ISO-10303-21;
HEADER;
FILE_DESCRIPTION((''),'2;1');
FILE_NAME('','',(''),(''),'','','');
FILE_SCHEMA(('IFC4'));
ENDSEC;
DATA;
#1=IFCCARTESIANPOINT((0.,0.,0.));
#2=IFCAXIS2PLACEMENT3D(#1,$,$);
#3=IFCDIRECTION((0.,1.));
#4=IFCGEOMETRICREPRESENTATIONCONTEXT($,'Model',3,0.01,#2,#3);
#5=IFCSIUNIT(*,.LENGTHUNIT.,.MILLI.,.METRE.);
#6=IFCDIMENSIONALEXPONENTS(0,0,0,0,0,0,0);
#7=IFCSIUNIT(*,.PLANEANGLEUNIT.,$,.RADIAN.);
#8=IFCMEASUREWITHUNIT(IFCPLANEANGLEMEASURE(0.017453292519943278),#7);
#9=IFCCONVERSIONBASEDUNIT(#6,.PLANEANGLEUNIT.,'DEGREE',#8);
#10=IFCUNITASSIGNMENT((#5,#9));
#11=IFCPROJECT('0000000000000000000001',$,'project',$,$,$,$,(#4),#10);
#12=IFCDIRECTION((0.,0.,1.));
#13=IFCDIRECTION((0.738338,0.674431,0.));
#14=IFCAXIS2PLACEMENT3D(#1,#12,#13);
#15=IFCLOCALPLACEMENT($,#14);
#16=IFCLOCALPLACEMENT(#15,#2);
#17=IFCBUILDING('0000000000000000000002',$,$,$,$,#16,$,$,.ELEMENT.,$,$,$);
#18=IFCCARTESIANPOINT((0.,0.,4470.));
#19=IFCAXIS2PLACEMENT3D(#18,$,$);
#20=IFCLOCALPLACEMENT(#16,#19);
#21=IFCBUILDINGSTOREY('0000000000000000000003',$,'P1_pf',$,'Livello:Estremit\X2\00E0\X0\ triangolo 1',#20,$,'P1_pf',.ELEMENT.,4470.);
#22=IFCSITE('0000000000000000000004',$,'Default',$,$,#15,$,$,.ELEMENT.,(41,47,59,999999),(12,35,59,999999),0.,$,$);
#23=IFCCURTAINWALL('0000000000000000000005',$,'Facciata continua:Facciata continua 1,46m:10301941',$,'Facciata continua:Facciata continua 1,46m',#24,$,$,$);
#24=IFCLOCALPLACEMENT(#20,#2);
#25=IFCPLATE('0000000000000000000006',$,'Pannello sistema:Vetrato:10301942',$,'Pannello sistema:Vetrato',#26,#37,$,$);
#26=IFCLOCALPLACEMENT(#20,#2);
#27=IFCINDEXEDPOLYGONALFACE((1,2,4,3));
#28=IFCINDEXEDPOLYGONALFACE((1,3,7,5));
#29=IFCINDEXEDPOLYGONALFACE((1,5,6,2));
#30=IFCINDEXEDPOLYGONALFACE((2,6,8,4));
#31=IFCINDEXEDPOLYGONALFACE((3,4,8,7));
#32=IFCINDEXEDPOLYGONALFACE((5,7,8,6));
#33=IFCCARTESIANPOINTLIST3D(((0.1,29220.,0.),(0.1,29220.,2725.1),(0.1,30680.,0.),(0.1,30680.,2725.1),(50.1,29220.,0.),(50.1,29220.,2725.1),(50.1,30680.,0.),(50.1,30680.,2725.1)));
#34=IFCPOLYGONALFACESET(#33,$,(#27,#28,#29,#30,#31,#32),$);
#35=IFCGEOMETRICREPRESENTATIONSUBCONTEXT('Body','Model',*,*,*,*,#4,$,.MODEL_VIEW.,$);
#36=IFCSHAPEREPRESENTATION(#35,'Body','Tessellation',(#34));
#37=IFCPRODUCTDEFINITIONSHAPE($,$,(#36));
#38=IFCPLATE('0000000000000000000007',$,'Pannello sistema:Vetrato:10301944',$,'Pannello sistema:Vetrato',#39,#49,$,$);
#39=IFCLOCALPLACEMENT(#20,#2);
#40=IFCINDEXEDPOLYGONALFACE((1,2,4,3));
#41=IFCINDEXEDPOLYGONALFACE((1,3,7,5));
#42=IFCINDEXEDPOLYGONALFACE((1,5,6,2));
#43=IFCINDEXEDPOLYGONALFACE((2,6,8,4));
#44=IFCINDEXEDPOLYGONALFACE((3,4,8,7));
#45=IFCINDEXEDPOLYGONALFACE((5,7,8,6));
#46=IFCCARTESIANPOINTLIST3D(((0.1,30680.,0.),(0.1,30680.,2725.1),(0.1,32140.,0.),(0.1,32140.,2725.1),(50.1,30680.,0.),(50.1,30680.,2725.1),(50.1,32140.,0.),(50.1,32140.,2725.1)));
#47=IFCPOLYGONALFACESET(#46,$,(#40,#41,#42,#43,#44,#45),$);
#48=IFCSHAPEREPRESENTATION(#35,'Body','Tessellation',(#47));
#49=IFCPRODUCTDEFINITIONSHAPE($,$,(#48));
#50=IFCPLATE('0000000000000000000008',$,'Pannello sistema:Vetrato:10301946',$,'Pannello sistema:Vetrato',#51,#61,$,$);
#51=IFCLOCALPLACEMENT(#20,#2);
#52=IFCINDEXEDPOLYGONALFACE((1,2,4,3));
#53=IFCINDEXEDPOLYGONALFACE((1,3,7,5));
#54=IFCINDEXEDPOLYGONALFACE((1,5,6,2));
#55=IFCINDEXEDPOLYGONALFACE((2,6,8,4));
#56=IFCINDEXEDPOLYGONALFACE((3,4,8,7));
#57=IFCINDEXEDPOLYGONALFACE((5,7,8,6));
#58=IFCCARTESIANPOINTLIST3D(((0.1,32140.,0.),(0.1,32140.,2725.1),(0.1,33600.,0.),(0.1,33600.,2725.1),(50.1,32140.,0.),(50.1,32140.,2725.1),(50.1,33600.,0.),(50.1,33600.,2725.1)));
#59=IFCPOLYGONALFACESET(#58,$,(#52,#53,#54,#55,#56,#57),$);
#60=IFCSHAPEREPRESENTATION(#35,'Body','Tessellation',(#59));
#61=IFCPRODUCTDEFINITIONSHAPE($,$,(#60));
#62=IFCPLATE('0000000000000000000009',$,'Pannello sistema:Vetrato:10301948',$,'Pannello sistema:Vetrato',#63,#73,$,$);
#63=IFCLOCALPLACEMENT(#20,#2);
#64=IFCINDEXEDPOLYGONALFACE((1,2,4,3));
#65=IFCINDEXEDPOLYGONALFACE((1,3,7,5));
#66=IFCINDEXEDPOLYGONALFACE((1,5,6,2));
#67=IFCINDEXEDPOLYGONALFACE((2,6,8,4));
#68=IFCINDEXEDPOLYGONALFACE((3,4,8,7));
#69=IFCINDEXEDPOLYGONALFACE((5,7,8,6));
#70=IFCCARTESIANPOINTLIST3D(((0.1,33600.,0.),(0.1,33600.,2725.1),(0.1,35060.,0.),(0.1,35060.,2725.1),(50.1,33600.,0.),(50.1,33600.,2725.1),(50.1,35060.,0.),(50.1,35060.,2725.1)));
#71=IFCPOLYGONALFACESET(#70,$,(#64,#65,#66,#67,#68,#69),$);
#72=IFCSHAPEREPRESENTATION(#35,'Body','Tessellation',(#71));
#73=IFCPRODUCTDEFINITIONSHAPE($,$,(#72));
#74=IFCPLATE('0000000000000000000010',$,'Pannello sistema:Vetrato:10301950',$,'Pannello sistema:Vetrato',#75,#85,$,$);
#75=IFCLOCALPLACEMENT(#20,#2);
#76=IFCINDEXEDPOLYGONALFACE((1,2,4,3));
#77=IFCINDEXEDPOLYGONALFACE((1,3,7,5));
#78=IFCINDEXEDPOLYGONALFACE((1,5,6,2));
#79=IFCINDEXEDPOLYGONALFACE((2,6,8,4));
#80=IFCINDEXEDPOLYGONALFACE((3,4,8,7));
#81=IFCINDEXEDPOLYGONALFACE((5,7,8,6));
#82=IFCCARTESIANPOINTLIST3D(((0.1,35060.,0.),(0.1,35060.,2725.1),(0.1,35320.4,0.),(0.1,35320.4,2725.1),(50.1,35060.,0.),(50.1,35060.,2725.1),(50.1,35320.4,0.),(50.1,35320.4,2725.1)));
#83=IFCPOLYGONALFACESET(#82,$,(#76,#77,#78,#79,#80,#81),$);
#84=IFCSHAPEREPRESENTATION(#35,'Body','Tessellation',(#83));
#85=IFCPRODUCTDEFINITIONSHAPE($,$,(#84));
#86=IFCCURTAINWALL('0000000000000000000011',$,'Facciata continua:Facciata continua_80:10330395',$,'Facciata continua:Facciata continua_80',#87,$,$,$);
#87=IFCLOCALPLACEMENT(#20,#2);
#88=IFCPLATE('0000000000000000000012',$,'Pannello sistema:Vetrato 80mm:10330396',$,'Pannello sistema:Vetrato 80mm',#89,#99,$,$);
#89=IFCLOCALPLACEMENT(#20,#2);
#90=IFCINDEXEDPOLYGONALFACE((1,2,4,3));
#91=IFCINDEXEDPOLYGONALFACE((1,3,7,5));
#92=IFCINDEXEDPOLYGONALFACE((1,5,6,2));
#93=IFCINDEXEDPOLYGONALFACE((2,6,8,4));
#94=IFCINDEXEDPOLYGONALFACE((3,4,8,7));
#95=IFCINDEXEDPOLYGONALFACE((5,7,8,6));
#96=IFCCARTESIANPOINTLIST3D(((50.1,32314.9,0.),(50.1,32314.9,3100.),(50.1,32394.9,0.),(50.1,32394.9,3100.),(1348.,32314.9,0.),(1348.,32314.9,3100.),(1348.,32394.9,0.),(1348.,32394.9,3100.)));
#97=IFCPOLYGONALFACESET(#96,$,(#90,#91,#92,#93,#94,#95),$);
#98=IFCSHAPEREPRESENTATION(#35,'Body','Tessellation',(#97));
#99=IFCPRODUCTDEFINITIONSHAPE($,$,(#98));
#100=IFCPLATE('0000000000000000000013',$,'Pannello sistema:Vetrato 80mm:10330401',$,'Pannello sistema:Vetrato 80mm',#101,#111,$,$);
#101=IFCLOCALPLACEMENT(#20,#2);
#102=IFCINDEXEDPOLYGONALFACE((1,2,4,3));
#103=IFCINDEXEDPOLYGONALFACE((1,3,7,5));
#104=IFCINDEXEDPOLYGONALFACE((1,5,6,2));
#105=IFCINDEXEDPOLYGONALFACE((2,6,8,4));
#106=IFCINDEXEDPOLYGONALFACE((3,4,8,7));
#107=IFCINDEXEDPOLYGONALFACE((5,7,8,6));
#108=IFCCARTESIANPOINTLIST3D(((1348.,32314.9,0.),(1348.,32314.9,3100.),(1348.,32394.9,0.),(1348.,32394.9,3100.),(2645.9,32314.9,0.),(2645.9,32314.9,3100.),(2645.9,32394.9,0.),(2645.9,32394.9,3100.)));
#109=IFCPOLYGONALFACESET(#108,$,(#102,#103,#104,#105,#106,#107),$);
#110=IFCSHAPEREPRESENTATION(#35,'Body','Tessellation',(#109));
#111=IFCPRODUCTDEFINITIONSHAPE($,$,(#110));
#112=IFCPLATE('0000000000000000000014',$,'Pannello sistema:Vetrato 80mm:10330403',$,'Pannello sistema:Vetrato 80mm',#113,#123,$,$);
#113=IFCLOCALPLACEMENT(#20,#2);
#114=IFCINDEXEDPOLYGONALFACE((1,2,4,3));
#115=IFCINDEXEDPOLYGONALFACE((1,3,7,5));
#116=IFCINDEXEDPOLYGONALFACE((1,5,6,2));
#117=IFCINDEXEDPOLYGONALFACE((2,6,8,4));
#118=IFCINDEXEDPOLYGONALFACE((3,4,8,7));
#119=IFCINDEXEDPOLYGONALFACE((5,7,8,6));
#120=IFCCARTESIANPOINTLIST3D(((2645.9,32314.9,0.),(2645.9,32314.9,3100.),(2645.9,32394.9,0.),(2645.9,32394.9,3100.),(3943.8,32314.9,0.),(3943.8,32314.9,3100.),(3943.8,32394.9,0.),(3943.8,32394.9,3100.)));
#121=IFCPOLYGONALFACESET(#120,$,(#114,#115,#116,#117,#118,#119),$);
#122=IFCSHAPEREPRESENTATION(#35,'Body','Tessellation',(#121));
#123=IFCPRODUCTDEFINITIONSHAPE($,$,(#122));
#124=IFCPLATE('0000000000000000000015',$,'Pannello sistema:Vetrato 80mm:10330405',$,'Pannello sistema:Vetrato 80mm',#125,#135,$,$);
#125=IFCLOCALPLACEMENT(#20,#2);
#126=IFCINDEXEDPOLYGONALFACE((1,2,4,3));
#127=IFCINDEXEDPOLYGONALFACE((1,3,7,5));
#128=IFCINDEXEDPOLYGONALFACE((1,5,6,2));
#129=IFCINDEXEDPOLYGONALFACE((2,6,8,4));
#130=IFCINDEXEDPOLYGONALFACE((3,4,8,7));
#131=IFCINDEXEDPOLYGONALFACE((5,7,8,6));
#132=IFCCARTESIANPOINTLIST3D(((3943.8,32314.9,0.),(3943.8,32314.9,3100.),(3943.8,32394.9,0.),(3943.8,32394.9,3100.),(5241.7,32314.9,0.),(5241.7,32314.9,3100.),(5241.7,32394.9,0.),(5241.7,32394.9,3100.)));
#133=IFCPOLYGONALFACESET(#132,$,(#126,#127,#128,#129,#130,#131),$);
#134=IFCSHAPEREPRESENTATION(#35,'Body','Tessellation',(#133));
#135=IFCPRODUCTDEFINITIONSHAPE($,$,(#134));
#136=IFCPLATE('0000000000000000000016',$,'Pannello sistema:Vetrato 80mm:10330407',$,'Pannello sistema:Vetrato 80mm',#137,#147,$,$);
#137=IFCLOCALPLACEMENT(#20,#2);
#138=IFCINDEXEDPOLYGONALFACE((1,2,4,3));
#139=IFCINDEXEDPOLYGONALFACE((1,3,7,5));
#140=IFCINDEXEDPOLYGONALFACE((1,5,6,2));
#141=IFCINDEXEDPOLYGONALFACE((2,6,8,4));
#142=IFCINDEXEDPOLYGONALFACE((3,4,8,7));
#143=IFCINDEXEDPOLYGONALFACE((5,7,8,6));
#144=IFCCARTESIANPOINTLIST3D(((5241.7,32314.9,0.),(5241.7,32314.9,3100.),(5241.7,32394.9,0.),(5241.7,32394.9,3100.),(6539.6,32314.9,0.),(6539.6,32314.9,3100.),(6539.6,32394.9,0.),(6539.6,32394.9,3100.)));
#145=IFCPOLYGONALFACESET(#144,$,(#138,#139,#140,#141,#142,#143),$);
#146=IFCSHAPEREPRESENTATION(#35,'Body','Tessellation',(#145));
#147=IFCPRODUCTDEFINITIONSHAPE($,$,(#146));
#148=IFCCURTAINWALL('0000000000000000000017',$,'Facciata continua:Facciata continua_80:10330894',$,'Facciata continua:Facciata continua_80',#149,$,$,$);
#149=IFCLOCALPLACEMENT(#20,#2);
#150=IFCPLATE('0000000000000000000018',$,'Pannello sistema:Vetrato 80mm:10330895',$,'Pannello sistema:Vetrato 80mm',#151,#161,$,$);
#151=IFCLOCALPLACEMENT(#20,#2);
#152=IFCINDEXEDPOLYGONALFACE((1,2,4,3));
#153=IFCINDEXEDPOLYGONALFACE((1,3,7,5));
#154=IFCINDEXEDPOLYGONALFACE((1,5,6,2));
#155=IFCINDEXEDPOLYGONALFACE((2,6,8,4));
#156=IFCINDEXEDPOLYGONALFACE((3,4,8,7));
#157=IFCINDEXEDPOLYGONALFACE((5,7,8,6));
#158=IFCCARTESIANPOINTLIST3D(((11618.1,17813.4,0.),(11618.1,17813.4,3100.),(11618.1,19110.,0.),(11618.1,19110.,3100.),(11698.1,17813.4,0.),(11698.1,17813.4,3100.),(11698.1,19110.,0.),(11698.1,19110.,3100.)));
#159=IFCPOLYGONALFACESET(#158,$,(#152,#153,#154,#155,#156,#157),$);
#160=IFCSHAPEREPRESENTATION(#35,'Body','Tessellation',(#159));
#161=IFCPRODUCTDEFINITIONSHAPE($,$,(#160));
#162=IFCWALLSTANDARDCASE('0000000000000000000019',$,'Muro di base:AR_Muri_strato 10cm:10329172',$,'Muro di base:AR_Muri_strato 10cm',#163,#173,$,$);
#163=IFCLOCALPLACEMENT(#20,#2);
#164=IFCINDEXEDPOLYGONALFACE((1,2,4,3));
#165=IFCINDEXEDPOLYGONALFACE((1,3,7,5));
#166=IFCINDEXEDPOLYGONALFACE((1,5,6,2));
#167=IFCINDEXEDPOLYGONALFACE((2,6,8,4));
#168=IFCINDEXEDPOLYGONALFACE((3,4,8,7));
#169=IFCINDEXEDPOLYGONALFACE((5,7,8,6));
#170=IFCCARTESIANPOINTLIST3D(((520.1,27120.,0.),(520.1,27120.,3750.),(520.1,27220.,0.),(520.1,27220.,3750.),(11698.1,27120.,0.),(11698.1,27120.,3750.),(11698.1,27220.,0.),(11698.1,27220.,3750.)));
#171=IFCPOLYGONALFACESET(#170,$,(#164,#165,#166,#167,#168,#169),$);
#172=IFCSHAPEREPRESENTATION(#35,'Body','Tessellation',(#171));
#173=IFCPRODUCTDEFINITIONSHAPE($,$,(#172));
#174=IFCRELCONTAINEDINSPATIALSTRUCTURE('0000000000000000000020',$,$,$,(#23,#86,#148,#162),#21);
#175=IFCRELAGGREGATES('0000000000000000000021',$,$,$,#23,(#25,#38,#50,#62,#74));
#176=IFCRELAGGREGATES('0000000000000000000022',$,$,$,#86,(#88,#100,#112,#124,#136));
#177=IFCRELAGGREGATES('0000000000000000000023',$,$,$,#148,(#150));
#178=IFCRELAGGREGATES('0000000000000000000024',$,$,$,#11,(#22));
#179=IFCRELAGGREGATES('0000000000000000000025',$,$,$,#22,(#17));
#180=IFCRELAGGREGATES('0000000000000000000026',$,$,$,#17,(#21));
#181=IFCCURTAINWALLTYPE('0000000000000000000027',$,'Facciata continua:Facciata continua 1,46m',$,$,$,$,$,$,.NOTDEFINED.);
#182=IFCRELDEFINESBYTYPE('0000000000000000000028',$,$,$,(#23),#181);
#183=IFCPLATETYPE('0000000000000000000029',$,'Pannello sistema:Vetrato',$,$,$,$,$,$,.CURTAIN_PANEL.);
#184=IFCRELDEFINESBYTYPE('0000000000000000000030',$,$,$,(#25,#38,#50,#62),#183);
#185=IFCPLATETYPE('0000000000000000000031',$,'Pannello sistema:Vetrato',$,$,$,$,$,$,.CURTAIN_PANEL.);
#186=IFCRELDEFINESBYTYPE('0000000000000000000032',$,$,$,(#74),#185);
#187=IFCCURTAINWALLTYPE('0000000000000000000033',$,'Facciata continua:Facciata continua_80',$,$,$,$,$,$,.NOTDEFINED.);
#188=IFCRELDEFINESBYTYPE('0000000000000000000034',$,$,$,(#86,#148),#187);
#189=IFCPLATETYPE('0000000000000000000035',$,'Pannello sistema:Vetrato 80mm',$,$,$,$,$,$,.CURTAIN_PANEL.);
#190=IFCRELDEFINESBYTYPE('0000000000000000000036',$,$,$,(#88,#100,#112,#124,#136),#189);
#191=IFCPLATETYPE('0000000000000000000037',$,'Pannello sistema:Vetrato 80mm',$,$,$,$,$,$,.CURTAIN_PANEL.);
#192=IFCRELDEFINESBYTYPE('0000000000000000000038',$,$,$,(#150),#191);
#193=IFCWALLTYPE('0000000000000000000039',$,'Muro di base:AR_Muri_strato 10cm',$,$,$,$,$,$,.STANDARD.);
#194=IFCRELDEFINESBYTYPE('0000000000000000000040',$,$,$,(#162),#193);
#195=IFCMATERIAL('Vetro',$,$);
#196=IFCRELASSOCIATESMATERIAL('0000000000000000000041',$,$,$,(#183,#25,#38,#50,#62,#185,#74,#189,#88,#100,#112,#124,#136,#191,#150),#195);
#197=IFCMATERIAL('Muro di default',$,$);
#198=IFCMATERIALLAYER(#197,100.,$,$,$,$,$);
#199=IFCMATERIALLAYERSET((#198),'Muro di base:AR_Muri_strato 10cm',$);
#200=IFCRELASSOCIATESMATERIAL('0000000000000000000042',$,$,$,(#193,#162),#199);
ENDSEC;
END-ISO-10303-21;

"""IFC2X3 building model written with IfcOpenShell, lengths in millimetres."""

from ifc_helpers import new_model, entity, si_unit, converted_unit, direction, frame, frame_2d, origin, origin_2d_with_axis, place, context, subcontext, project, spatial, rectangle, extrude, source, transform, mapped, material, layer, layer_set, layer_usage, type_object, type_shapes, element, aggregate, save


model = new_model("IFC2X3")

# Units and contexts
model_context = context("Model", 3, precision=0.01, world=origin(), true_north=direction((0.0, 1.0)))
body_context = subcontext(model_context, "Body", "Model", "MODEL_VIEW")
ifc_project = project(units=[si_unit("LENGTHUNIT", "METRE", prefix="MILLI"), converted_unit("PLANEANGLEUNIT", "DEGREE", entity("IfcPlaneAngleMeasure", 0.017453292519943278), si_unit("PLANEANGLEUNIT", "RADIAN"), dimensions=[0, 0, 0, 0, 0, 0, 0])], contexts=[model_context])

# Site, building, storey
site_placement = place(None, frame((0.0, 0.0, 0.0), z_axis=(0.0, 0.0, 1.0), x_axis=(0.738338, 0.674431, 0.0)))
site = spatial("IfcSite", under=ifc_project, at=site_placement, Name="Default", CompositionType="ELEMENT", RefLatitude=(41, 47, 59, 999999), RefLongitude=(12, 35, 59, 999999), RefElevation=0.0)
building_placement = place(site_placement, origin())
building = spatial("IfcBuilding", under=site, at=building_placement, CompositionType="ELEMENT")
storey_placement = place(building_placement, frame((0.0, 0.0, 4470.0)))
storey = spatial("IfcBuildingStorey", under=building, at=storey_placement, Name="P1_pf", ObjectType="Livello:Estremità triangolo 1", LongName="P1_pf", CompositionType="ELEMENT", Elevation=4470.0)

# Curtain walls, plates
curtain_wall_type_1 = type_object("IfcCurtainWallType", Name="Facciata continua:Facciata continua 1,46m", PredefinedType="NOTDEFINED")
curtain_wall_1_placement = place(storey_placement, frame((0.0, 0.0, -4470.0)))
curtain_wall_1 = element("IfcCurtainWall", 1, at=curtain_wall_1_placement, inside=storey, type_object=curtain_wall_type_1, Name="Facciata continua:Facciata continua 1,46m:10301941", ObjectType="Facciata continua:Facciata continua 1,46m")
ifc_material_1 = material(Name="Vetro")
plate_type_1 = type_object("IfcPlateType", Name="Pannello sistema:Vetrato", PredefinedType="CURTAIN_PANEL", material=ifc_material_1)
shared_shape_1 = source(origin(), body_context, "Body", "SweptSolid", [
    extrude(rectangle(XDim=50.0, YDim=1460.0, at=origin_2d_with_axis()), frame((0.0, -25.0, 0.0), z_axis=(0.0, 0.0, 1.0), x_axis=(0.0, 1.0, 0.0)), (0.0, 0.0, 1.0), 2725.1),
])
type_shapes(plate_type_1, [shared_shape_1])
plate_1_placement = place(curtain_wall_1_placement, frame((0.1, 29950.0, 4470.0), z_axis=(0.0, 0.0, 1.0), x_axis=(0.0, 1.0, 0.0)))
plate_1 = element("IfcPlate", 2, at=plate_1_placement, type_object=plate_type_1, material=ifc_material_1, Name="Pannello sistema:Vetrato:10301942", ObjectType="Pannello sistema:Vetrato", context=body_context, shape_type="MappedRepresentation", body=[
    mapped(shared_shape_1, transform((0.0, 0.0, 0.0), scale=1.0)),
])
plate_2_placement = place(curtain_wall_1_placement, frame((0.1, 31410.0, 4470.0), z_axis=(0.0, 0.0, 1.0), x_axis=(0.0, 1.0, 0.0)))
plate_2 = element("IfcPlate", 3, at=plate_2_placement, type_object=plate_type_1, material=ifc_material_1, Name="Pannello sistema:Vetrato:10301944", ObjectType="Pannello sistema:Vetrato", context=body_context, shape_type="MappedRepresentation", body=[
    mapped(shared_shape_1, transform((0.0, 0.0, 0.0), scale=1.0)),
])
plate_3_placement = place(curtain_wall_1_placement, frame((0.1, 32870.0, 4470.0), z_axis=(0.0, 0.0, 1.0), x_axis=(0.0, 1.0, 0.0)))
plate_3 = element("IfcPlate", 4, at=plate_3_placement, type_object=plate_type_1, material=ifc_material_1, Name="Pannello sistema:Vetrato:10301946", ObjectType="Pannello sistema:Vetrato", context=body_context, shape_type="MappedRepresentation", body=[
    mapped(shared_shape_1, transform((0.0, 0.0, 0.0), scale=1.0)),
])
plate_4_placement = place(curtain_wall_1_placement, frame((0.1, 34330.0, 4470.0), z_axis=(0.0, 0.0, 1.0), x_axis=(0.0, 1.0, 0.0)))
plate_4 = element("IfcPlate", 5, at=plate_4_placement, type_object=plate_type_1, material=ifc_material_1, Name="Pannello sistema:Vetrato:10301948", ObjectType="Pannello sistema:Vetrato", context=body_context, shape_type="MappedRepresentation", body=[
    mapped(shared_shape_1, transform((0.0, 0.0, 0.0), scale=1.0)),
])
plate_type_2 = type_object("IfcPlateType", Name="Pannello sistema:Vetrato", PredefinedType="CURTAIN_PANEL", material=ifc_material_1)
shared_shape_2 = source(origin(), body_context, "Body", "SweptSolid", [
    extrude(rectangle(XDim=50.0, YDim=260.4, at=origin_2d_with_axis()), frame((0.0, -25.0, 0.0), z_axis=(0.0, 0.0, 1.0), x_axis=(0.0, 1.0, 0.0)), (0.0, 0.0, 1.0), 2725.1),
])
type_shapes(plate_type_2, [shared_shape_2])
plate_5_placement = place(curtain_wall_1_placement, frame((0.1, 35190.2, 4470.0), z_axis=(0.0, 0.0, 1.0), x_axis=(0.0, 1.0, 0.0)))
plate_5 = element("IfcPlate", 6, at=plate_5_placement, type_object=plate_type_2, material=ifc_material_1, Name="Pannello sistema:Vetrato:10301950", ObjectType="Pannello sistema:Vetrato", context=body_context, shape_type="MappedRepresentation", body=[
    mapped(shared_shape_2, transform((0.0, 0.0, 0.0), scale=1.0)),
])
aggregate(curtain_wall_1, [plate_1, plate_2, plate_3, plate_4, plate_5])
curtain_wall_type_2 = type_object("IfcCurtainWallType", Name="Facciata continua:Facciata continua_80", PredefinedType="NOTDEFINED")
curtain_wall_2_placement = place(storey_placement, frame((0.0, 0.0, -4470.0)))
curtain_wall_2 = element("IfcCurtainWall", 7, at=curtain_wall_2_placement, inside=storey, type_object=curtain_wall_type_2, Name="Facciata continua:Facciata continua_80:10330395", ObjectType="Facciata continua:Facciata continua_80")
plate_type_3 = type_object("IfcPlateType", Name="Pannello sistema:Vetrato 80mm", PredefinedType="CURTAIN_PANEL", material=ifc_material_1)
shared_shape_3 = source(origin(), body_context, "Body", "SweptSolid", [
    extrude(rectangle(XDim=80.0, YDim=1297.9, at=origin_2d_with_axis()), frame((0.0, -40.0, 0.0), z_axis=(0.0, 0.0, 1.0), x_axis=(0.0, 1.0, 0.0)), (0.0, 0.0, 1.0), 3100.0),
])
type_shapes(plate_type_3, [shared_shape_3])
plate_6_placement = place(curtain_wall_2_placement, frame((699.0, 32394.9, 4470.0)))
plate_6 = element("IfcPlate", 8, at=plate_6_placement, type_object=plate_type_3, material=ifc_material_1, Name="Pannello sistema:Vetrato 80mm:10330396", ObjectType="Pannello sistema:Vetrato 80mm", context=body_context, shape_type="MappedRepresentation", body=[
    mapped(shared_shape_3, transform((0.0, 0.0, 0.0), scale=1.0)),
])
plate_7_placement = place(curtain_wall_2_placement, frame((1996.9, 32394.9, 4470.0)))
plate_7 = element("IfcPlate", 9, at=plate_7_placement, type_object=plate_type_3, material=ifc_material_1, Name="Pannello sistema:Vetrato 80mm:10330401", ObjectType="Pannello sistema:Vetrato 80mm", context=body_context, shape_type="MappedRepresentation", body=[
    mapped(shared_shape_3, transform((0.0, 0.0, 0.0), scale=1.0)),
])
plate_8_placement = place(curtain_wall_2_placement, frame((3294.8, 32394.9, 4470.0)))
plate_8 = element("IfcPlate", 10, at=plate_8_placement, type_object=plate_type_3, material=ifc_material_1, Name="Pannello sistema:Vetrato 80mm:10330403", ObjectType="Pannello sistema:Vetrato 80mm", context=body_context, shape_type="MappedRepresentation", body=[
    mapped(shared_shape_3, transform((0.0, 0.0, 0.0), scale=1.0)),
])
plate_9_placement = place(curtain_wall_2_placement, frame((4592.7, 32394.9, 4470.0)))
plate_9 = element("IfcPlate", 11, at=plate_9_placement, type_object=plate_type_3, material=ifc_material_1, Name="Pannello sistema:Vetrato 80mm:10330405", ObjectType="Pannello sistema:Vetrato 80mm", context=body_context, shape_type="MappedRepresentation", body=[
    mapped(shared_shape_3, transform((0.0, 0.0, 0.0), scale=1.0)),
])
plate_10_placement = place(curtain_wall_2_placement, frame((5890.6, 32394.9, 4470.0)))
plate_10 = element("IfcPlate", 12, at=plate_10_placement, type_object=plate_type_3, material=ifc_material_1, Name="Pannello sistema:Vetrato 80mm:10330407", ObjectType="Pannello sistema:Vetrato 80mm", context=body_context, shape_type="MappedRepresentation", body=[
    mapped(shared_shape_3, transform((0.0, 0.0, 0.0), scale=1.0)),
])
aggregate(curtain_wall_2, [plate_6, plate_7, plate_8, plate_9, plate_10])

# Curtain wall, plate
curtain_wall_3_placement = place(storey_placement, frame((0.0, 0.0, -4470.0)))
curtain_wall_3 = element("IfcCurtainWall", 13, at=curtain_wall_3_placement, inside=storey, type_object=curtain_wall_type_2, Name="Facciata continua:Facciata continua_80:10330894", ObjectType="Facciata continua:Facciata continua_80")
plate_type_4 = type_object("IfcPlateType", Name="Pannello sistema:Vetrato 80mm", PredefinedType="CURTAIN_PANEL", material=ifc_material_1)
shared_shape_4 = source(origin(), body_context, "Body", "SweptSolid", [
    extrude(rectangle(XDim=80.0, YDim=1296.7, at=origin_2d_with_axis()), frame((0.0, -40.0, 0.0), z_axis=(0.0, 0.0, 1.0), x_axis=(0.0, 1.0, 0.0)), (0.0, 0.0, 1.0), 3100.0),
])
type_shapes(plate_type_4, [shared_shape_4])
plate_11_placement = place(curtain_wall_3_placement, frame((11698.1, 18461.7, 4470.0), z_axis=(0.0, 0.0, 1.0), x_axis=(0.0, -1.0, 0.0)))
plate_11 = element("IfcPlate", 14, at=plate_11_placement, type_object=plate_type_4, material=ifc_material_1, Name="Pannello sistema:Vetrato 80mm:10330895", ObjectType="Pannello sistema:Vetrato 80mm", context=body_context, shape_type="MappedRepresentation", body=[
    mapped(shared_shape_4, transform((0.0, 0.0, 0.0), scale=1.0)),
])
aggregate(curtain_wall_3, [plate_11])

# Wall
ifc_material_2 = material(Name="Muro di default")
ifc_layer_1 = layer(ifc_material_2, 100.0)
ifc_layer_set_1 = layer_set([ifc_layer_1], Name="Muro di base:AR_Muri_strato 10cm")
ifc_layer_usage_1 = layer_usage(ifc_layer_set_1, "AXIS2", "NEGATIVE", 50.0)
wall_type_1 = type_object("IfcWallType", Name="Muro di base:AR_Muri_strato 10cm", PredefinedType="STANDARD", material=ifc_layer_set_1)
wall_1_placement = place(storey_placement, frame((520.1, 27170.0, 0.0)))
element("IfcWallStandardCase", 15, at=wall_1_placement, inside=storey, type_object=wall_type_1, material=ifc_layer_usage_1, Name="Muro di base:AR_Muri_strato 10cm:10329172", ObjectType="Muro di base:AR_Muri_strato 10cm", context=body_context, shape_type="SweptSolid", body=[
    extrude(rectangle(XDim=11178.0, YDim=100.0, at=frame_2d((5589.0, 0.0), x_axis=(-1.0, 0.0))), origin(), (0.0, 0.0, 1.0), 3750.0),
])

save(model, "model.ifc")
